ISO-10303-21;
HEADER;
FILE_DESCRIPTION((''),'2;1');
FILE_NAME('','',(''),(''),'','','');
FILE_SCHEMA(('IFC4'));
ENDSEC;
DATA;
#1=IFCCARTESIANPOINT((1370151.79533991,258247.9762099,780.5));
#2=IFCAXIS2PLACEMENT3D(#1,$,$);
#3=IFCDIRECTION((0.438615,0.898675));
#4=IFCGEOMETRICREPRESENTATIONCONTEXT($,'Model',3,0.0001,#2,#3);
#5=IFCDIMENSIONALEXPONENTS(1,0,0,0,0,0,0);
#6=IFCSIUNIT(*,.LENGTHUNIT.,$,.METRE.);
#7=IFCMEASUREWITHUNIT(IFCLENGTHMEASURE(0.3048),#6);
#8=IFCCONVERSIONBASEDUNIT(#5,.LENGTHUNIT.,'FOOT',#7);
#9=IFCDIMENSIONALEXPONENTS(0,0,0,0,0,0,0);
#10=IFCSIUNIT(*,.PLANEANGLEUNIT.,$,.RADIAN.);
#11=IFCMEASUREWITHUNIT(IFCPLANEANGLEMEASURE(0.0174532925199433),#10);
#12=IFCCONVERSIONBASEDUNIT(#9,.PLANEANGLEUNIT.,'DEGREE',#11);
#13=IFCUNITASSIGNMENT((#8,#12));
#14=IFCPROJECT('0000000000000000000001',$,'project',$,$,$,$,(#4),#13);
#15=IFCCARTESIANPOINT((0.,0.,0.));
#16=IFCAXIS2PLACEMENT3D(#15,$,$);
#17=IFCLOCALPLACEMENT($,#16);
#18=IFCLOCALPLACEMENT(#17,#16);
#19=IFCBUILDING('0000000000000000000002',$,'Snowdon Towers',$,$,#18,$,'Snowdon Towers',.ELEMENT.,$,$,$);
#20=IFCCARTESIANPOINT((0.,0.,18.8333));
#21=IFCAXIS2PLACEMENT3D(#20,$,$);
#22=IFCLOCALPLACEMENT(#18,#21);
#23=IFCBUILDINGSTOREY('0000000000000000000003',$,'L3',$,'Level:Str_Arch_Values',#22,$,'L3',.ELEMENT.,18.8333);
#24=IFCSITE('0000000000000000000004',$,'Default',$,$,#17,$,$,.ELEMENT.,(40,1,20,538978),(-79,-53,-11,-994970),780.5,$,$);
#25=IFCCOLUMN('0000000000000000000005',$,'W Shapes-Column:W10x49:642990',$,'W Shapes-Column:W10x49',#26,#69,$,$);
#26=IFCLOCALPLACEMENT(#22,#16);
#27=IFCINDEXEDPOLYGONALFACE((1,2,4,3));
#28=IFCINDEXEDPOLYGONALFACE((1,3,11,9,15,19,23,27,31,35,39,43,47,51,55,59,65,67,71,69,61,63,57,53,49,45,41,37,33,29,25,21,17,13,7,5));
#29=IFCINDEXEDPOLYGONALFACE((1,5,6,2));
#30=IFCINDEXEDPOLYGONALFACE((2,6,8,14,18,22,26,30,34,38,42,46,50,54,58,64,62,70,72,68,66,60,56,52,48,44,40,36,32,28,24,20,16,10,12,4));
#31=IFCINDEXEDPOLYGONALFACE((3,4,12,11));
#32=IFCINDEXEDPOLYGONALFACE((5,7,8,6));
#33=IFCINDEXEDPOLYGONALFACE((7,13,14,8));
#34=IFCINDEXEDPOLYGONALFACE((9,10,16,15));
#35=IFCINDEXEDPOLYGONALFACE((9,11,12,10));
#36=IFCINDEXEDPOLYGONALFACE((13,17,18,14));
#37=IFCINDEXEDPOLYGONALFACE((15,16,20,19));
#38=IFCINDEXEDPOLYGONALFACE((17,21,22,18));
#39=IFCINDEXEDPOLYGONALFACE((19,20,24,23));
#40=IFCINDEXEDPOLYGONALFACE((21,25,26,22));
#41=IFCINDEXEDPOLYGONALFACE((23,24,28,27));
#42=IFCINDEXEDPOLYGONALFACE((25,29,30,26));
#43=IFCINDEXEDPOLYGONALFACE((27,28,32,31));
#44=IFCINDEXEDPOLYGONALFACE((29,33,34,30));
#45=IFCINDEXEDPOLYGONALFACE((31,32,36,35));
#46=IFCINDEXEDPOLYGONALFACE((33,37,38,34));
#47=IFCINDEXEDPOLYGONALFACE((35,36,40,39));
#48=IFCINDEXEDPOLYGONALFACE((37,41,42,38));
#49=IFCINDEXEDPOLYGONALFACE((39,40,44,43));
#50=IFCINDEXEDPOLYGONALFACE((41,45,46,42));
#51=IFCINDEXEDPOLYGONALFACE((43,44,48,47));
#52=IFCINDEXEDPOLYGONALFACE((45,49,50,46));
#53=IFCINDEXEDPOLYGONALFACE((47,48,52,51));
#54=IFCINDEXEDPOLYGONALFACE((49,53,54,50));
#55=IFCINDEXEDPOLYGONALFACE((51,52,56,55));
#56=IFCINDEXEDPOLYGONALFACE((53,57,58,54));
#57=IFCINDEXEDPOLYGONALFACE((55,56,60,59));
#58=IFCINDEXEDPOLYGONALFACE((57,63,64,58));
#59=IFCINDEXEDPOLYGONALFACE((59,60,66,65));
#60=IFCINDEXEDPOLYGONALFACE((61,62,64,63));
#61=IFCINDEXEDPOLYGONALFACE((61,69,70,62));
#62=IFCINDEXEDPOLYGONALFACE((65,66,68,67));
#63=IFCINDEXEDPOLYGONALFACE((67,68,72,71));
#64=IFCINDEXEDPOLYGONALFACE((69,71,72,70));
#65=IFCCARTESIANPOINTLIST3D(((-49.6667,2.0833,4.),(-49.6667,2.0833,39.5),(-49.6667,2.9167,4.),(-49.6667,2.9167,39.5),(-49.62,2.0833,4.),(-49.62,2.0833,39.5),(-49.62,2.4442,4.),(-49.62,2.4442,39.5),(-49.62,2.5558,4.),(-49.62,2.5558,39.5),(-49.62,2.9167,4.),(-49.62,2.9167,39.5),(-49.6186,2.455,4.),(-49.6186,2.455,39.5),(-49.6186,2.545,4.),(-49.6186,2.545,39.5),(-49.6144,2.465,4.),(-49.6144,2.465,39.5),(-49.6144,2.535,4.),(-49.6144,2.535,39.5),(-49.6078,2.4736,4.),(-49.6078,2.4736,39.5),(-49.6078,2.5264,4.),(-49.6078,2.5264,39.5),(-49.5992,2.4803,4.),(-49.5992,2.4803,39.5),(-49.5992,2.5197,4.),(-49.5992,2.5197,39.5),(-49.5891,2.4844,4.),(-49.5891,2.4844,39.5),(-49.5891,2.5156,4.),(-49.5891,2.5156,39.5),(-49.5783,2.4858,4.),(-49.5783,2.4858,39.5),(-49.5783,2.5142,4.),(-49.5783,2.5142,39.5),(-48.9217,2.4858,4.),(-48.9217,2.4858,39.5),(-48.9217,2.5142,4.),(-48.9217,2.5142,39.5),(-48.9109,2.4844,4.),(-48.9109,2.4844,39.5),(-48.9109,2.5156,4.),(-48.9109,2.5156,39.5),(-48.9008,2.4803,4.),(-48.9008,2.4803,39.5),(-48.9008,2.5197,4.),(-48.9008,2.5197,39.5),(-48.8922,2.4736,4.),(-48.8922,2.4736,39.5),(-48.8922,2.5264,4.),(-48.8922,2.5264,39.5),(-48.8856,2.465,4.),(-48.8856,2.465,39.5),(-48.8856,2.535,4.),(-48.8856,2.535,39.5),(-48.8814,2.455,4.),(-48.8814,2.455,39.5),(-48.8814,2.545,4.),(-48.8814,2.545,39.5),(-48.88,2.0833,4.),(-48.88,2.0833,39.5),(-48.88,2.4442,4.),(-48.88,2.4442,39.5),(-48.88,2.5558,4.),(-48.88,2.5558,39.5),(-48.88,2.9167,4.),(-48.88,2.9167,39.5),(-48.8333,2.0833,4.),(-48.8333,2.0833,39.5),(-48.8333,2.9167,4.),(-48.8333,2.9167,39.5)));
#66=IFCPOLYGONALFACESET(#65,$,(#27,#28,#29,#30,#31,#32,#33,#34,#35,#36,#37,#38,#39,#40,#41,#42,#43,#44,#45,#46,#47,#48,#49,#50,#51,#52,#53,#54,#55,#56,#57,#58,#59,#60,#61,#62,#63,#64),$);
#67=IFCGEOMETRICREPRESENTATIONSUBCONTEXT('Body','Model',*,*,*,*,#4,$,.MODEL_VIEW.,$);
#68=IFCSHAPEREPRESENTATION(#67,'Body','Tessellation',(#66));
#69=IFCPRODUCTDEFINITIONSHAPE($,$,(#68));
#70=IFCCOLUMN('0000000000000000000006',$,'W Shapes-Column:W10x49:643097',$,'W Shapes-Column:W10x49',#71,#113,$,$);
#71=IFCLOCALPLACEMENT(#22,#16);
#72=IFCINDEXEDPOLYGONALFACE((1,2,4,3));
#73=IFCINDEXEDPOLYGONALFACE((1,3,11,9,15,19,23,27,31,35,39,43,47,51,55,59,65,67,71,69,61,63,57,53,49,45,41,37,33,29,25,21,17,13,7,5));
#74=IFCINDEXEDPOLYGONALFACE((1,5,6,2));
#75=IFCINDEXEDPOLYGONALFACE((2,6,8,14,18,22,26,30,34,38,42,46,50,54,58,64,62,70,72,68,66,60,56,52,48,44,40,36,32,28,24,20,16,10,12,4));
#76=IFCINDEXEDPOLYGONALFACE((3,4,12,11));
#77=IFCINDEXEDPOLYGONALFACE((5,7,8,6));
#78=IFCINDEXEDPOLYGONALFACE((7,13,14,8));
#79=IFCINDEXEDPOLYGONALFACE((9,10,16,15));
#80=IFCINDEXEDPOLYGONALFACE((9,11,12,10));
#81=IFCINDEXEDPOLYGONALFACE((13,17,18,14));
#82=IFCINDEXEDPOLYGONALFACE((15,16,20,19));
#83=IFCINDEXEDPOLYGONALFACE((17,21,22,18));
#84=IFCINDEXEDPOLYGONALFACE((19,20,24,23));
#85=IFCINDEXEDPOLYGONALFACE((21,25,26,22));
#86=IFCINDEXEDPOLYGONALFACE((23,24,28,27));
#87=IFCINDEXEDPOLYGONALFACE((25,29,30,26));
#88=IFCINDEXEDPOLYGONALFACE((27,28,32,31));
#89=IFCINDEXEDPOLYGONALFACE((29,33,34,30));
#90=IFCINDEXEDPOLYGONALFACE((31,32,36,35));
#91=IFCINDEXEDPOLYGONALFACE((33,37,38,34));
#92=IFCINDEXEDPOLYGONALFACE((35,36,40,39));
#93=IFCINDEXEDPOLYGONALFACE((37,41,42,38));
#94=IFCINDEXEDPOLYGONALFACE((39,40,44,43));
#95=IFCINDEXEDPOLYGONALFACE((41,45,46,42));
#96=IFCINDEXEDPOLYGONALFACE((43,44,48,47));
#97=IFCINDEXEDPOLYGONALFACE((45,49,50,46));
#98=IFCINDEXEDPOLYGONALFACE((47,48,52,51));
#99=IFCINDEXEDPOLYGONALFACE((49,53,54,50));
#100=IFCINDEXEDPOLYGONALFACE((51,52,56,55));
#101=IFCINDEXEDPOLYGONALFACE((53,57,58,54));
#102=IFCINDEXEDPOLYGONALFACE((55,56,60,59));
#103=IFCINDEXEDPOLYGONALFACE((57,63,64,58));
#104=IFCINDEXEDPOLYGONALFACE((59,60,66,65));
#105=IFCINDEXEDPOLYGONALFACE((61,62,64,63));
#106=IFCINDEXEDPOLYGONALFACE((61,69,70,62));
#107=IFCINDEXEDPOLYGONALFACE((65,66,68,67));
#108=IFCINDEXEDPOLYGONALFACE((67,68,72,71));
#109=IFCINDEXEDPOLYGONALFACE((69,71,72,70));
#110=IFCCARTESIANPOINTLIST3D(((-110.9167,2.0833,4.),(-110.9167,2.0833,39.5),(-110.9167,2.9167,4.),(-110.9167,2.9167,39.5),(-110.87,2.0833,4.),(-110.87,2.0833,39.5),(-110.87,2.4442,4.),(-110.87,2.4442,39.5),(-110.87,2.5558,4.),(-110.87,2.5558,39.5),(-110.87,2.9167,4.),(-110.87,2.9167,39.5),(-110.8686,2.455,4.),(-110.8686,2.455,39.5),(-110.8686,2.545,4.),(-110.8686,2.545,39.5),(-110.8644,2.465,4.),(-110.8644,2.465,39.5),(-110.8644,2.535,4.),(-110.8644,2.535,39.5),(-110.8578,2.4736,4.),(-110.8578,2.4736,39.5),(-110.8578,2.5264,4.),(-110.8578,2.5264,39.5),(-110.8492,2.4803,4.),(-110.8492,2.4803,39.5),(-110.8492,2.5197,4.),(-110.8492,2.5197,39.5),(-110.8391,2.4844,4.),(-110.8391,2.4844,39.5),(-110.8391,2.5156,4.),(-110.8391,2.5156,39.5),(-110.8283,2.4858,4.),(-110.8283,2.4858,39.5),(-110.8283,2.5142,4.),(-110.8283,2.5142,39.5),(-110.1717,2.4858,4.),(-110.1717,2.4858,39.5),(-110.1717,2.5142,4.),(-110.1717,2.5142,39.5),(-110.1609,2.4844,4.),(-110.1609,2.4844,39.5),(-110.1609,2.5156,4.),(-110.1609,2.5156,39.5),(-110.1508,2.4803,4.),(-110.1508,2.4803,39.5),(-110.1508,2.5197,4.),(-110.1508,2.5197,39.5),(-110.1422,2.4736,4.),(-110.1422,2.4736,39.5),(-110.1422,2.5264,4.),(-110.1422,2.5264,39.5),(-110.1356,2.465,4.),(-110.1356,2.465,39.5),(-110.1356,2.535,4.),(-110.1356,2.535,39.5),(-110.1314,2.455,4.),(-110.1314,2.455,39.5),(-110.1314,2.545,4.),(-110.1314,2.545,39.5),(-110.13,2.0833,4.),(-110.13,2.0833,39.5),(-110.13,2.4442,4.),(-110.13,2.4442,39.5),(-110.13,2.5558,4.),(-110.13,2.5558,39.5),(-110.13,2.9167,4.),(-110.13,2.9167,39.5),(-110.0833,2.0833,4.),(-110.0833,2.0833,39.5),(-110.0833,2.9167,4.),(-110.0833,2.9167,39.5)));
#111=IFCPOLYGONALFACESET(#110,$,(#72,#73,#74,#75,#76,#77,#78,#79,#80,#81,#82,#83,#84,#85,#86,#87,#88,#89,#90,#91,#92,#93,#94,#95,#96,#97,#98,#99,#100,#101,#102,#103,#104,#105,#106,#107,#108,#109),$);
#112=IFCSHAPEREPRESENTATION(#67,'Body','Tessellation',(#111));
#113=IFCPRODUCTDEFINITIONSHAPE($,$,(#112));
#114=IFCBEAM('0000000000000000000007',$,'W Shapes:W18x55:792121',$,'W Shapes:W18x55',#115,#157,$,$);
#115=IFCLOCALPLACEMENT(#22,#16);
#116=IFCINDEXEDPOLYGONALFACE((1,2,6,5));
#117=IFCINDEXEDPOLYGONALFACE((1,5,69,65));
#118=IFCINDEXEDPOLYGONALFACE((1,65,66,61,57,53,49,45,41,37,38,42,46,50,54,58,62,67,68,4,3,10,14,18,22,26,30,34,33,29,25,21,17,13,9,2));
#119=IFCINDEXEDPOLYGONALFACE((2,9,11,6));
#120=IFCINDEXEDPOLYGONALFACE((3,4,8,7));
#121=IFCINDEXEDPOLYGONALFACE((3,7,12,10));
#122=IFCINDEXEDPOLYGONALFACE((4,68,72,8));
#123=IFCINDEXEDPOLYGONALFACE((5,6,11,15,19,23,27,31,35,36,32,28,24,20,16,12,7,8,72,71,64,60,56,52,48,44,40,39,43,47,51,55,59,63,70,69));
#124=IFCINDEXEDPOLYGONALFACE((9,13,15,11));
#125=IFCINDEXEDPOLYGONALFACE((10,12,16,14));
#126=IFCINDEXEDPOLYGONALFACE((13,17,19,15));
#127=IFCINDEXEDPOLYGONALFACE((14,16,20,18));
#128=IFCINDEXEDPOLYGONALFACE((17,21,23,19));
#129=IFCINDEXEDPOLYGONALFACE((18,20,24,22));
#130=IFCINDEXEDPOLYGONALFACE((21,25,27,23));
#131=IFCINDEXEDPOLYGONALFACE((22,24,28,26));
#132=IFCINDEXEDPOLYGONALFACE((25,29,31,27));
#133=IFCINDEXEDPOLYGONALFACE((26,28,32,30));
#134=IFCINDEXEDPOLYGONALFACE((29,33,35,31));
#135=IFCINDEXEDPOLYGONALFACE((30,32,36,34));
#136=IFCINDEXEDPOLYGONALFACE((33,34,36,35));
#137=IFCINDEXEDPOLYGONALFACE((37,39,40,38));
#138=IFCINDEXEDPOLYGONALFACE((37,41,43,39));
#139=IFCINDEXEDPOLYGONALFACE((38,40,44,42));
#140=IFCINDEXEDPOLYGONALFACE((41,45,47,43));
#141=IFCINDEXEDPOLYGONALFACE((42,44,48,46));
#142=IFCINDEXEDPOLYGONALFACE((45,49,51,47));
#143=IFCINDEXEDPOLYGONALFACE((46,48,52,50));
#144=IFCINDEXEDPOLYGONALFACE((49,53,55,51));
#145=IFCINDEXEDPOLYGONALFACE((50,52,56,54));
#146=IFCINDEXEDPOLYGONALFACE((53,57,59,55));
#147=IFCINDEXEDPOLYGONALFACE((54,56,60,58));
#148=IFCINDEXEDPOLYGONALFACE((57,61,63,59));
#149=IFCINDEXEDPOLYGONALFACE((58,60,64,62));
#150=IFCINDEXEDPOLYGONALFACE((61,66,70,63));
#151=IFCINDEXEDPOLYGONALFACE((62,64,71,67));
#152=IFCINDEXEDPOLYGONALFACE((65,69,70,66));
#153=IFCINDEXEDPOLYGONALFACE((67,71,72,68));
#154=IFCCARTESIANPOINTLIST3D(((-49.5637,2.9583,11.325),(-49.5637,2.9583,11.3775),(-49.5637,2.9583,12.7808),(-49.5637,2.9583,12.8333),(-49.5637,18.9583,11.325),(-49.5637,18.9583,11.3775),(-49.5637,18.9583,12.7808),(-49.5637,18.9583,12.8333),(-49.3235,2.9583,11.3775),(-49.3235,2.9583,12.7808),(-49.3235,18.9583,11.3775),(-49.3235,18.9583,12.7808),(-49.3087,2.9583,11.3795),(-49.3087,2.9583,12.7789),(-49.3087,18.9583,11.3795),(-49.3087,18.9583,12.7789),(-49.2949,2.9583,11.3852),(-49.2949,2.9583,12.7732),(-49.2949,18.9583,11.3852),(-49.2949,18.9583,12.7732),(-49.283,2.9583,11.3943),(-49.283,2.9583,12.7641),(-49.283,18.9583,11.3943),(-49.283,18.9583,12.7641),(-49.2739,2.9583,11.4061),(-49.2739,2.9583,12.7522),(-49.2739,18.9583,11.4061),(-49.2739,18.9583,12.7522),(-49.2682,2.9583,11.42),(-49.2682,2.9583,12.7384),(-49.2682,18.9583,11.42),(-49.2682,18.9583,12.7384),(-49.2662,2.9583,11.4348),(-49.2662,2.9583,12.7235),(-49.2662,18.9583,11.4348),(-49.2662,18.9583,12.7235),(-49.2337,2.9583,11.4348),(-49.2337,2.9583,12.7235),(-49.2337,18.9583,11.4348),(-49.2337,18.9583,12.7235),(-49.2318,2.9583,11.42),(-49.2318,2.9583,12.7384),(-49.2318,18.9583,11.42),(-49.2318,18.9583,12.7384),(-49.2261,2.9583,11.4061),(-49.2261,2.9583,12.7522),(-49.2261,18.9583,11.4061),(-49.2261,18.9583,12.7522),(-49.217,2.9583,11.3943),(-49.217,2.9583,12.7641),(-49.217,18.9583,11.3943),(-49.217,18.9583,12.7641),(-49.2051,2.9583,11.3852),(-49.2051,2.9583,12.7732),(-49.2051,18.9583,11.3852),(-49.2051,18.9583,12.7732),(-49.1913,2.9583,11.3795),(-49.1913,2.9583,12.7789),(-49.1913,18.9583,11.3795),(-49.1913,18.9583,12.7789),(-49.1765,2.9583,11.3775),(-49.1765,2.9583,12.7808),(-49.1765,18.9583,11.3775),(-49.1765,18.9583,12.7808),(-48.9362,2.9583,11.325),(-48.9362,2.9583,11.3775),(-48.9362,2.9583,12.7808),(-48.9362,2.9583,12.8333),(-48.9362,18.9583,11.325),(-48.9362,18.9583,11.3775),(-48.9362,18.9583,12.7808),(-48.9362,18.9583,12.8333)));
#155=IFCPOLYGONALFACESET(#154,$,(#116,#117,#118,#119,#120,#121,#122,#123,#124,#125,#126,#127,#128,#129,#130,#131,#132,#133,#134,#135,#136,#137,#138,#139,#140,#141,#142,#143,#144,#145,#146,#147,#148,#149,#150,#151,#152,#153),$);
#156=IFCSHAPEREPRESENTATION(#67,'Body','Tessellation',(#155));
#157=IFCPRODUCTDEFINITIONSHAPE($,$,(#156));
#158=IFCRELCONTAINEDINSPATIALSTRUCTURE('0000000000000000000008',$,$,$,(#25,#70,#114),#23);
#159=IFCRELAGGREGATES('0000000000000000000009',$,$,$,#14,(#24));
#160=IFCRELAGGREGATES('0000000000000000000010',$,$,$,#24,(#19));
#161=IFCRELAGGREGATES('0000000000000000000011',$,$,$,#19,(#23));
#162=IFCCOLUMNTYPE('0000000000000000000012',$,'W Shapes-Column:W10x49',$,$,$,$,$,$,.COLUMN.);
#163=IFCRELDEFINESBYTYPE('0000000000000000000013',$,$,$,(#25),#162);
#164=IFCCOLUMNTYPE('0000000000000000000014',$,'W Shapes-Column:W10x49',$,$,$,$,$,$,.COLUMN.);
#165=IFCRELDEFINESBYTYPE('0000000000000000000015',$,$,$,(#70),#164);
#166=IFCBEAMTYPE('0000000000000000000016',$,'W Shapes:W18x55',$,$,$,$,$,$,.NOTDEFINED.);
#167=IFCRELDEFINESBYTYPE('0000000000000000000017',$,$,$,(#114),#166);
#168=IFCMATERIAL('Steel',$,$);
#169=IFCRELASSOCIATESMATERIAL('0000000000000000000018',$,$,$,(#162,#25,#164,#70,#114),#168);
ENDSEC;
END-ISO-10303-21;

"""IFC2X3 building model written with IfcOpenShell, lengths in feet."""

from ifc_helpers import new_model, entity, si_unit, converted_unit, direction, frame, frame_2d, origin, place, context, subcontext, project, spatial, i_section, extrude, source, transform, mapped, material, type_object, type_shapes, element, save


model = new_model("IFC2X3")

# Units and contexts
model_context = context("Model", 3, precision=0.0001, world=frame((1370151.79533991, 258247.9762099, 780.5)), true_north=direction((0.438615, 0.898675)))
body_context = subcontext(model_context, "Body", "Model", "MODEL_VIEW")
ifc_project = project(units=[converted_unit("LENGTHUNIT", "FOOT", entity("IfcLengthMeasure", 0.3048), si_unit("LENGTHUNIT", "METRE"), dimensions=[1, 0, 0, 0, 0, 0, 0]), converted_unit("PLANEANGLEUNIT", "DEGREE", entity("IfcPlaneAngleMeasure", 0.0174532925199433), si_unit("PLANEANGLEUNIT", "RADIAN"), dimensions=[0, 0, 0, 0, 0, 0, 0])], contexts=[model_context])

# Site, building, storey
site_placement = place(None, origin())
site = spatial("IfcSite", under=ifc_project, at=site_placement, Name="Default", CompositionType="ELEMENT", RefLatitude=(40, 1, 20, 538978), RefLongitude=(-79, -53, -11, -994970), RefElevation=780.5)
building_placement = place(site_placement, origin())
building = spatial("IfcBuilding", under=site, at=building_placement, Name="Snowdon Towers", LongName="Snowdon Towers", CompositionType="ELEMENT")
storey_placement = place(building_placement, frame((0.0, 0.0, 18.8333)))
storey = spatial("IfcBuildingStorey", under=building, at=storey_placement, Name="L3", ObjectType="Level:Str_Arch_Values", LongName="L3", CompositionType="ELEMENT", Elevation=18.8333)

# Columns
ifc_material_1 = material(Name="Steel")
column_type_1 = type_object("IfcColumnType", Name="W Shapes-Column:W10x49", PredefinedType="COLUMN", material=ifc_material_1)
shared_shape_1 = source(origin(), body_context, "Body", "SweptSolid", [
    extrude(i_section(OverallWidth=0.8333, OverallDepth=0.8333, WebThickness=0.0283, FlangeThickness=0.0467, FilletRadius=0.0417, at=frame_2d((0.0, 0.0), x_axis=(1.0, 0.0))), frame((0.0, 0.0, 22.8333), z_axis=(0.0, 0.0, 1.0), x_axis=(-1.0, 0.0, 0.0)), (0.0, 0.0, 1.0), 35.5),
])
type_shapes(column_type_1, [shared_shape_1])
column_1_placement = place(storey_placement, frame((-49.25, 2.5, -18.8333), z_axis=(0.0, 0.0, 1.0), x_axis=(0.0, 1.0, 0.0)))
element("IfcColumn", 1, at=column_1_placement, inside=storey, type_object=column_type_1, material=ifc_material_1, Name="W Shapes-Column:W10x49:642990", ObjectType="W Shapes-Column:W10x49", context=body_context, shape_type="MappedRepresentation", body=[
    mapped(shared_shape_1, transform((0.0, 0.0, 0.0), scale=1.0)),
])
column_type_2 = type_object("IfcColumnType", Name="W Shapes-Column:W10x49", PredefinedType="COLUMN", material=ifc_material_1)
shared_shape_2 = source(origin(), body_context, "Body", "SweptSolid", [
    extrude(i_section(OverallWidth=0.8333, OverallDepth=0.8333, WebThickness=0.0283, FlangeThickness=0.0467, FilletRadius=0.0417, at=frame_2d((0.0, 0.0), x_axis=(1.0, 0.0))), frame((0.0, 0.0, 22.8333), z_axis=(0.0, 0.0, 1.0), x_axis=(-1.0, 0.0, 0.0)), (0.0, 0.0, 1.0), 35.5),
])
type_shapes(column_type_2, [shared_shape_2])
column_2_placement = place(storey_placement, frame((-110.5, 2.5, -18.8333), z_axis=(0.0, 0.0, 1.0), x_axis=(0.0, 1.0, 0.0)))
element("IfcColumn", 2, at=column_2_placement, inside=storey, type_object=column_type_2, material=ifc_material_1, Name="W Shapes-Column:W10x49:643097", ObjectType="W Shapes-Column:W10x49", context=body_context, shape_type="MappedRepresentation", body=[
    mapped(shared_shape_2, transform((0.0, 0.0, 0.0), scale=1.0)),
])

# Beam
beam_type_1 = type_object("IfcBeamType", Name="W Shapes:W18x55", PredefinedType="NOTDEFINED")
beam_1_placement = place(storey_placement, frame((-49.25, 19.2083, 12.8333), z_axis=(0.0, 0.0, 1.0), x_axis=(0.0, -1.0, 0.0)))
element("IfcBeam", 3, at=beam_1_placement, inside=storey, type_object=beam_type_1, material=ifc_material_1, Name="W Shapes:W18x55:792121", ObjectType="W Shapes:W18x55", context=body_context, shape_type="SweptSolid", body=[
    extrude(i_section(OverallWidth=0.6275, OverallDepth=1.5083, WebThickness=0.0325, FlangeThickness=0.0525, FilletRadius=0.0573, at=frame_2d((0.0, 0.0), x_axis=(0.0, 1.0))), frame((0.25, 0.0, -0.7542), z_axis=(1.0, 0.0, 0.0), x_axis=(0.0, 0.0, -1.0)), (0.0, 0.0, 1.0), 16.0),
])

save(model, "model.ifc")
